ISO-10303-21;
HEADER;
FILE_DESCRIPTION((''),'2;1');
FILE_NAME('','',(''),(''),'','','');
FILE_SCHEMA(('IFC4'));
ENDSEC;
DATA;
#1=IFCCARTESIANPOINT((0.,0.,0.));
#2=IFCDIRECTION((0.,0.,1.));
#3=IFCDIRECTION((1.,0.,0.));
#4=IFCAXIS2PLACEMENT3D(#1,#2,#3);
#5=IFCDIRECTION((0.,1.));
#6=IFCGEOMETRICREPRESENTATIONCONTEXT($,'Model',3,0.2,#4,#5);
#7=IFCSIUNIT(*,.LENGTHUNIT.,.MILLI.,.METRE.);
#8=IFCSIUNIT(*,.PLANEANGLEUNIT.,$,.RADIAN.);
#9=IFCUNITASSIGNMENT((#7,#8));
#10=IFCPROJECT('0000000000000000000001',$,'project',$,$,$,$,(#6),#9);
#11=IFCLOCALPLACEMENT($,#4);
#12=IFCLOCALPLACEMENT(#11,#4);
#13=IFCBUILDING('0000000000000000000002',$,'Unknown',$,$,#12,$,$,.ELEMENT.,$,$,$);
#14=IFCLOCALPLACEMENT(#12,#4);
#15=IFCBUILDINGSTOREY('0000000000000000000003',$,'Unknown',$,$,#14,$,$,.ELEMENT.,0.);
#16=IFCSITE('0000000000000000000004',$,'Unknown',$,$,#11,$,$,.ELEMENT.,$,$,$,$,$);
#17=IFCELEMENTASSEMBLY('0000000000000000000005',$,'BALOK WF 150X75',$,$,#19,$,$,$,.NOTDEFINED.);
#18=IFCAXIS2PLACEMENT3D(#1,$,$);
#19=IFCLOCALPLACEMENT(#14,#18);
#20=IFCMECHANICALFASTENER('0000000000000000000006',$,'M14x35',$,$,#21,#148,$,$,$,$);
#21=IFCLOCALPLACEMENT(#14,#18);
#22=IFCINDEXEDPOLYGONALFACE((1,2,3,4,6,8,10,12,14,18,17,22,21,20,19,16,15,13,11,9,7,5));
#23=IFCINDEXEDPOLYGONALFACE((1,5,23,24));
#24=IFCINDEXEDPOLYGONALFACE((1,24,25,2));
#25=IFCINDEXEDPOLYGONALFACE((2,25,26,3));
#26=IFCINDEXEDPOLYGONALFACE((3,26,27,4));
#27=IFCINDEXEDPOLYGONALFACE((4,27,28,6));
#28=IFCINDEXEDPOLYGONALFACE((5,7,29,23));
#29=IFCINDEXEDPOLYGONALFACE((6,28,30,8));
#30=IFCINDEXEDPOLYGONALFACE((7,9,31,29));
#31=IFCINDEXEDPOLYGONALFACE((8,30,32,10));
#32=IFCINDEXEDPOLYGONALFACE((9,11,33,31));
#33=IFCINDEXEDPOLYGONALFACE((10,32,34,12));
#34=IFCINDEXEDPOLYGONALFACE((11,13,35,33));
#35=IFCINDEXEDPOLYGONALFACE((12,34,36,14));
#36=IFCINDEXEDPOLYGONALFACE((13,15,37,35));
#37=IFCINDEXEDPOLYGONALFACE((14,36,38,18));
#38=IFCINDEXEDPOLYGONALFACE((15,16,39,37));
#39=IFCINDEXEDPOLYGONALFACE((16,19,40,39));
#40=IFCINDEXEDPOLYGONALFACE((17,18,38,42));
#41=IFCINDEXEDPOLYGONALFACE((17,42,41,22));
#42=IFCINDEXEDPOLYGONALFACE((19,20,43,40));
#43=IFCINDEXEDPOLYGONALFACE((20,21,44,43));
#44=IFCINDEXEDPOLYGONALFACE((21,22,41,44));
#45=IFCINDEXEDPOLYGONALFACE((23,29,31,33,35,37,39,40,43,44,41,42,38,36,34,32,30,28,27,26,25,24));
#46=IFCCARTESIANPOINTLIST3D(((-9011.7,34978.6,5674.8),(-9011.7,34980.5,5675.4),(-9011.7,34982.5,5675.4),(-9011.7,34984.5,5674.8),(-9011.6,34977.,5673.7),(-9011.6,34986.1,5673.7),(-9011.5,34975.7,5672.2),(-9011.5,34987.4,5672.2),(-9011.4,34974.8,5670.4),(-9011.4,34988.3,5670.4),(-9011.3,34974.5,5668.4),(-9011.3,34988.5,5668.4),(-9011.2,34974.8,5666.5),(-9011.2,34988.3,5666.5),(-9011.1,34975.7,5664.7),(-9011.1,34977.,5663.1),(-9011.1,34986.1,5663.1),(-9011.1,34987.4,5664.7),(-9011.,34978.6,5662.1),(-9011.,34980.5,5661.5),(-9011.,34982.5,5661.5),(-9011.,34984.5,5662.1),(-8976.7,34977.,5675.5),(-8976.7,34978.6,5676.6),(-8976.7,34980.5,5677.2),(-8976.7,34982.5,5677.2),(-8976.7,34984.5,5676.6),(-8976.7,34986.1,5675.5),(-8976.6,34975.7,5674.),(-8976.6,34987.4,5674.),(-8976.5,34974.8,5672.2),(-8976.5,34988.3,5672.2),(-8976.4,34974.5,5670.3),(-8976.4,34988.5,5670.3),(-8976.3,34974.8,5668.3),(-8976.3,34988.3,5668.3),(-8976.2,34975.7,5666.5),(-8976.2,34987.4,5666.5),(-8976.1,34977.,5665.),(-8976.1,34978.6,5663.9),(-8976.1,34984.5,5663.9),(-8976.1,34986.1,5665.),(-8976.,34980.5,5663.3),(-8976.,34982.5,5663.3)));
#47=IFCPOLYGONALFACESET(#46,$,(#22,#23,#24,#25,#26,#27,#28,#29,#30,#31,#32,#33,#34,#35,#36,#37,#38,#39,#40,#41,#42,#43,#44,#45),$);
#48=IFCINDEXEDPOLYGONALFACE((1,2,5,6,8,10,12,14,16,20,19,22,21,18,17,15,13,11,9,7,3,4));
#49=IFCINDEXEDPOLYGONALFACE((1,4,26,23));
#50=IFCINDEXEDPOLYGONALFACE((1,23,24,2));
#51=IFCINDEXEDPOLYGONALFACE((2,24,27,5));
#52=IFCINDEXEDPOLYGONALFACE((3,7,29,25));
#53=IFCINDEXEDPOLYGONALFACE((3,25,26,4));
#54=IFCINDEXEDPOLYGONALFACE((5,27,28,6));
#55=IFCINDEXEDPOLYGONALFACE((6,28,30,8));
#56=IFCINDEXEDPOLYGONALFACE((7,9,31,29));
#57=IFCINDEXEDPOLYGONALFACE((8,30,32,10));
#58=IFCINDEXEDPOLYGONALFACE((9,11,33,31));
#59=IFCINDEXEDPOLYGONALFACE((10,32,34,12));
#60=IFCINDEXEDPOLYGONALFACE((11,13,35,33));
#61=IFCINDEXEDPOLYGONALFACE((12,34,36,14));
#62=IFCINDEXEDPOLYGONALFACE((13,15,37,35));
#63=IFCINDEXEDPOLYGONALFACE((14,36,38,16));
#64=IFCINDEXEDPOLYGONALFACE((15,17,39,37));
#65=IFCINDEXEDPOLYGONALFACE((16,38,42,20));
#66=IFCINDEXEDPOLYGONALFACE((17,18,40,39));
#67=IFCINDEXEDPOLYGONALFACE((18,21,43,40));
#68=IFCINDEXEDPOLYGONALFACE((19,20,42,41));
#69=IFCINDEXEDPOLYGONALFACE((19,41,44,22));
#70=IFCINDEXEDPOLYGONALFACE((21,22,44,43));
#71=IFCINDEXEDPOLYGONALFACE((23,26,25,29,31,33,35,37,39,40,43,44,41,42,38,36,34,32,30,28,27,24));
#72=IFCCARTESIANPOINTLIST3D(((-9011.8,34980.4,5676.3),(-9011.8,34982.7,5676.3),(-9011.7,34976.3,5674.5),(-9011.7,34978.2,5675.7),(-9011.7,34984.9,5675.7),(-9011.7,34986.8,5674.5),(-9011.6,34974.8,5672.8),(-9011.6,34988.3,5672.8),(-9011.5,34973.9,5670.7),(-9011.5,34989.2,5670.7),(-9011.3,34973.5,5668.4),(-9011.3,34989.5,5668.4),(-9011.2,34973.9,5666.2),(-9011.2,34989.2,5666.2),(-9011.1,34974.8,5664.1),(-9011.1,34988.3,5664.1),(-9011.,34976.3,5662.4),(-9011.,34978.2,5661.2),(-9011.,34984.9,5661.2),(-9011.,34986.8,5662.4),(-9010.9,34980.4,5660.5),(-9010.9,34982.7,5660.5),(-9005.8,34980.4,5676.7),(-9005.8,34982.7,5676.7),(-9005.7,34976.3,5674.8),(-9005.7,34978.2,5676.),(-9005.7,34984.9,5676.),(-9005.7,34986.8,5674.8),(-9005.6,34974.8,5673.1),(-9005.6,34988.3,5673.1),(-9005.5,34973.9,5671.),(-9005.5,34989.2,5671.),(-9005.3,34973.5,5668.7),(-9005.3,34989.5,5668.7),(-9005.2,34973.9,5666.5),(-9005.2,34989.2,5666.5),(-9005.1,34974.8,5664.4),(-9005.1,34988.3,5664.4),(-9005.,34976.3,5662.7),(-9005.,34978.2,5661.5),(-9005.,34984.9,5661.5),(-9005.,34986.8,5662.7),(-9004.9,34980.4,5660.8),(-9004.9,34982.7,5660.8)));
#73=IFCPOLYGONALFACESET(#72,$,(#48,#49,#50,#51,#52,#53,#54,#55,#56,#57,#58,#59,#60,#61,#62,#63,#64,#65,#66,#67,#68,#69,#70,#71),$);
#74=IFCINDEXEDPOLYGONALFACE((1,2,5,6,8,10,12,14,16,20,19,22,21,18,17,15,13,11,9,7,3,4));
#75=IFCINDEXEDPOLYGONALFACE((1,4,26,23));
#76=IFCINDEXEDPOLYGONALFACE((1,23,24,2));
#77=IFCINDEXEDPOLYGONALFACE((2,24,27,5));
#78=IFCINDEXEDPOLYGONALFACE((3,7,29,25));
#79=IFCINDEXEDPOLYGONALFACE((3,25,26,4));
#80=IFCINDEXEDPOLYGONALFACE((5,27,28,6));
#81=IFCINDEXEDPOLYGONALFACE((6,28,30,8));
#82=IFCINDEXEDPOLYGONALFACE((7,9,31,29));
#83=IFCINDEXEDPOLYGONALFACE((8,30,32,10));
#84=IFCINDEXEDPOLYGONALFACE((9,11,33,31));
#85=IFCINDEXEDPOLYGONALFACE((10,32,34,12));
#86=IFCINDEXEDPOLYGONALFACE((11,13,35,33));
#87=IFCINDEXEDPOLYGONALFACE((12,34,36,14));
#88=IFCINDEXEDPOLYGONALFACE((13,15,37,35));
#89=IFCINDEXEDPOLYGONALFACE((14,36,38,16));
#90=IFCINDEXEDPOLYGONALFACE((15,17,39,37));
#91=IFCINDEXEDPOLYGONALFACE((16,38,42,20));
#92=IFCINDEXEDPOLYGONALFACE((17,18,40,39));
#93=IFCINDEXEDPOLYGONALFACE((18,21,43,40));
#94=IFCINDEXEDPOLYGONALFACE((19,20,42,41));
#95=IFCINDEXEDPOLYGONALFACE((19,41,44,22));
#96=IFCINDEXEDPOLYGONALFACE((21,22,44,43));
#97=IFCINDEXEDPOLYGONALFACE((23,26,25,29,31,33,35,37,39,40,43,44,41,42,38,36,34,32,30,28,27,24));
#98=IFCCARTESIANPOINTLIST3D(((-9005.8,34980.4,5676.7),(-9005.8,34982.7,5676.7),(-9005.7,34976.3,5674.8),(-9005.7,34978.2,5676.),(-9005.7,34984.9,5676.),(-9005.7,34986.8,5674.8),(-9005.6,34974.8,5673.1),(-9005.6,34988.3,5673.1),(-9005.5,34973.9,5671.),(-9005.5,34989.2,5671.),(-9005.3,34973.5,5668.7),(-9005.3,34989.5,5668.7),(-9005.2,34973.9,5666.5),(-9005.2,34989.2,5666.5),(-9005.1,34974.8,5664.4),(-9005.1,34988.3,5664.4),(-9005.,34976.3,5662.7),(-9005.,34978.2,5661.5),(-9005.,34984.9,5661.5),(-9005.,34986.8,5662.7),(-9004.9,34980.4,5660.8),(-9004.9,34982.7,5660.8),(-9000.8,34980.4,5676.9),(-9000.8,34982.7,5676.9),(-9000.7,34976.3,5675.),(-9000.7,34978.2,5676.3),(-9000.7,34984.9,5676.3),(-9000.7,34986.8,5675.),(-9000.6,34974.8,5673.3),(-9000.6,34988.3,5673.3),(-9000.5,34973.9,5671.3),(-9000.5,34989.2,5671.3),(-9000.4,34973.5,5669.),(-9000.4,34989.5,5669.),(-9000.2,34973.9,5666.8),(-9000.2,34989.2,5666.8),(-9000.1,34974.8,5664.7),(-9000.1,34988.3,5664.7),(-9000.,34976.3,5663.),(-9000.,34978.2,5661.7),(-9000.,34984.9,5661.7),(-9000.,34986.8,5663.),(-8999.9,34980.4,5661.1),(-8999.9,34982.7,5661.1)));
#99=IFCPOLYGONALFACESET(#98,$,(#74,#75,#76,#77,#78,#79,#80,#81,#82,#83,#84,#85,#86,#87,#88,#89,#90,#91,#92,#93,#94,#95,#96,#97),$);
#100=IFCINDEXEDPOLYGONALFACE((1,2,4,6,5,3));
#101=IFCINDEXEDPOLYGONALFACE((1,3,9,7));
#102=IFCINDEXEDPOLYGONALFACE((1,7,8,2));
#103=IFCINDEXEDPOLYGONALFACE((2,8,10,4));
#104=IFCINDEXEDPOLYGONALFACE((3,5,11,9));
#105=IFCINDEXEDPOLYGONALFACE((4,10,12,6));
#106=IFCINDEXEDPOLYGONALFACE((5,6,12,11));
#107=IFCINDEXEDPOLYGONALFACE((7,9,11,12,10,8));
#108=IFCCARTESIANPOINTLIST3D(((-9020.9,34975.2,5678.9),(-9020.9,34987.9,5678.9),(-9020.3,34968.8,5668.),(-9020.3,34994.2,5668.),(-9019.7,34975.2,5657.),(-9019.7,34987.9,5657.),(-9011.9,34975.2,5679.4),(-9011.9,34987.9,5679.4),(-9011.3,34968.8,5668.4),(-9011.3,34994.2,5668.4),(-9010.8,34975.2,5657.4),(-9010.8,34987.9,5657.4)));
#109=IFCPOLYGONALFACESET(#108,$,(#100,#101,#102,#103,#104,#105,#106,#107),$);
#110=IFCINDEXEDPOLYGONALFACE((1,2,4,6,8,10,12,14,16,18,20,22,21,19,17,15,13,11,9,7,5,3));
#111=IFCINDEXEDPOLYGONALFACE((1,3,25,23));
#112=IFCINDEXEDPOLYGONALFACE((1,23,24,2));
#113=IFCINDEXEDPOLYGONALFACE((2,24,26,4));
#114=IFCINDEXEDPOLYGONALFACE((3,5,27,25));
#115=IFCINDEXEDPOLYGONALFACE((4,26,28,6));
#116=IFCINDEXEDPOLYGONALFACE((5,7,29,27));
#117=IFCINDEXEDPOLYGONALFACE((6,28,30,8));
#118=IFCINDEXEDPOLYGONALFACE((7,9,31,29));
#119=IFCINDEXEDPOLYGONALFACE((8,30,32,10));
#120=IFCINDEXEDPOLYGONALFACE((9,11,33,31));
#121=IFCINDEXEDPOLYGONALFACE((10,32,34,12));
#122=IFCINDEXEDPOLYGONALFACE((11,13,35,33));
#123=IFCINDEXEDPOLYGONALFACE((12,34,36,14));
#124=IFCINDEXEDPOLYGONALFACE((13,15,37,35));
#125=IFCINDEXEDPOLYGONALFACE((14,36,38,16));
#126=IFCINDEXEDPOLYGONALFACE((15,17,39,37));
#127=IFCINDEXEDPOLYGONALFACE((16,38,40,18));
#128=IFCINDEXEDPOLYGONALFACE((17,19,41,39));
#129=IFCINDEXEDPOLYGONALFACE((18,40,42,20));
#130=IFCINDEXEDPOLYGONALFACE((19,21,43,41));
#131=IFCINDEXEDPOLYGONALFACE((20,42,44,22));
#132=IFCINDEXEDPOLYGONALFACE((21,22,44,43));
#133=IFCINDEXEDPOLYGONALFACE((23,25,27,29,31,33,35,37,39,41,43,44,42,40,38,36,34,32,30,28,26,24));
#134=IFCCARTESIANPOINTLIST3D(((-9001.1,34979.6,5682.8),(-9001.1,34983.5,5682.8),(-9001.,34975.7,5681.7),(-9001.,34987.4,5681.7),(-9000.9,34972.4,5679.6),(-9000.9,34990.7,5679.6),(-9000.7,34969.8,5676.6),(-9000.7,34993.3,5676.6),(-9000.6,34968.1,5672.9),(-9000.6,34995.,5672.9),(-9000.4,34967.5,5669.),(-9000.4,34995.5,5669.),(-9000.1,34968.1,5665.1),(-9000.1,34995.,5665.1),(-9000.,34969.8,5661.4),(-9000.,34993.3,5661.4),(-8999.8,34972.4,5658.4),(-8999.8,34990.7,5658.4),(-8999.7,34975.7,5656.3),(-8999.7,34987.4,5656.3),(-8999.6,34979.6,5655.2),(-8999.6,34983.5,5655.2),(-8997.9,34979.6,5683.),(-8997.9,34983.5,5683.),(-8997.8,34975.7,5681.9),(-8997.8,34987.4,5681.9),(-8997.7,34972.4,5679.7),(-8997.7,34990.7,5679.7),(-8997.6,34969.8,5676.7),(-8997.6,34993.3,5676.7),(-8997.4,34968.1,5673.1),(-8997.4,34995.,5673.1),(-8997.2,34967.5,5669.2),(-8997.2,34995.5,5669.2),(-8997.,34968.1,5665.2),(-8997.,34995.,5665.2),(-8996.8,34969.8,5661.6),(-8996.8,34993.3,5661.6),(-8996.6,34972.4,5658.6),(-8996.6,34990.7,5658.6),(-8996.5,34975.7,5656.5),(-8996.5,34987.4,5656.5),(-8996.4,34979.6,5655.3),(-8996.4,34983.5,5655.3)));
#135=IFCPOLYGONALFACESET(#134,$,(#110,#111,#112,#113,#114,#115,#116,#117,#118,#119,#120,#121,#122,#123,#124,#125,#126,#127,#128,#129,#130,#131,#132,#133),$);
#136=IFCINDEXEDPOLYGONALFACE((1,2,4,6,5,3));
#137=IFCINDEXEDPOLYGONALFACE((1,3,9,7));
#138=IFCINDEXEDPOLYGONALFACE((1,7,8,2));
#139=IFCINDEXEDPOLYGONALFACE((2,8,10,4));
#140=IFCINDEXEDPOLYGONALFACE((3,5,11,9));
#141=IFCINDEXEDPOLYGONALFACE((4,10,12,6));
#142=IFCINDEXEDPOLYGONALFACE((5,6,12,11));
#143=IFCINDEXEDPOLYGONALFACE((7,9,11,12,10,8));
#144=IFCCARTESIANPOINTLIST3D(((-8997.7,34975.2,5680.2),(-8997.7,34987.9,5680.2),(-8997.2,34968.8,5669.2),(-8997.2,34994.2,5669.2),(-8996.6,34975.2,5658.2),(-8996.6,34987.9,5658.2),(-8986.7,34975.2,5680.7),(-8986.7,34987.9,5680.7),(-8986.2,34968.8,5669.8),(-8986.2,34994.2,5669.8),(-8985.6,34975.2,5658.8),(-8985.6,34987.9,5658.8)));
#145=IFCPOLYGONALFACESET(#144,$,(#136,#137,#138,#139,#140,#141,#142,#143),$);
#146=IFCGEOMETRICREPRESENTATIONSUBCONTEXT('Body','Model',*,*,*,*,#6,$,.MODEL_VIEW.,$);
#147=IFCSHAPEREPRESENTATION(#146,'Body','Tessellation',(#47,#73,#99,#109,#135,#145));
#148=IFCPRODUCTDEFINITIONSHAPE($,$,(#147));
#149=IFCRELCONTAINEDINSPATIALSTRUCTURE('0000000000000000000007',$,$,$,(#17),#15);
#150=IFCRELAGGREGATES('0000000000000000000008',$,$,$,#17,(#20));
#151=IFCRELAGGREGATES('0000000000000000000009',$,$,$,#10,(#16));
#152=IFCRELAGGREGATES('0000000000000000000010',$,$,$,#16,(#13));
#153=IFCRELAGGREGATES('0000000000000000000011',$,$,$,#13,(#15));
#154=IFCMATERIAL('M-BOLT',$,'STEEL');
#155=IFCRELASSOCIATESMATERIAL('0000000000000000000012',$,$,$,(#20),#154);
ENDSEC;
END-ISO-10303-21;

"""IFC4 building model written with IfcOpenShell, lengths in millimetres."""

from ifc_helpers import new_model, si_unit, direction, frame, origin_with_axes, place, context, subcontext, project, spatial, line, arc, indexed_curve, outline, extrude, source, transform, mapped, material, element, aggregate, save


model = new_model("IFC4")

# Units and contexts
model_context = context("Model", 3, precision=0.2, world=origin_with_axes(), true_north=direction((0.0, 1.0)))
body_context = subcontext(model_context, "Body", "Model", "MODEL_VIEW")
ifc_project = project(units=[si_unit("LENGTHUNIT", "METRE", prefix="MILLI"), si_unit("PLANEANGLEUNIT", "RADIAN")], contexts=[model_context])

# Site, building, storey
site_placement = place(None, origin_with_axes())
site = spatial("IfcSite", under=ifc_project, at=site_placement, Name="Unknown", CompositionType="ELEMENT")
building_placement = place(site_placement, origin_with_axes())
building = spatial("IfcBuilding", under=site, at=building_placement, Name="Unknown", CompositionType="ELEMENT")
storey_placement = place(building_placement, origin_with_axes())
storey = spatial("IfcBuildingStorey", under=building, at=storey_placement, Name="Unknown", CompositionType="ELEMENT", Elevation=0.0)

# Shared definitions
ifc_material_1 = material(Name="M-BOLT", Category="STEEL")

# Element assembly, mechanical fastener
assembly_1_placement = place(storey_placement, frame((-9001.5, 35225.4, 5643.9), z_axis=(-0.99863, 0.0, -0.052336), x_axis=(0.0, -1.0, 0.000001)))
assembly_1 = element("IfcElementAssembly", 1, at=assembly_1_placement, inside=storey, Name="BALOK WF 150X75", PredefinedType="NOTDEFINED")
shared_shape_1 = source(origin_with_axes(), body_context, "Body", "SweptSolid", [
    extrude(outline(indexed_curve([(7.0, 0.0), (0.0, 7.0), (-7.0, 0.0), (0.0, -7.0)], segments=[arc(1, 2, 3), arc(3, 4, 1)])), frame((0.0, 0.0, 0.0), z_axis=(0.0, 0.0, -1.0), x_axis=(0.0, 1.0, 0.0)), (0.0, 0.0, 1.0), 35.0),
    extrude(outline(indexed_curve([(8.0, 0.0), (0.0, 8.0), (-8.0, 0.0), (0.0, -8.0)], segments=[arc(1, 2, 3), arc(3, 4, 1)])), frame((0.0, 0.0, 0.0), z_axis=(0.0, 0.0, -1.0), x_axis=(0.0, 1.0, 0.0)), (0.0, 0.0, 1.0), 6.0),
    extrude(outline(indexed_curve([(8.0, 0.0), (0.0, 8.0), (-8.0, 0.0), (0.0, -8.0)], segments=[arc(1, 2, 3), arc(3, 4, 1)])), frame((0.0, 0.0, -6.0), z_axis=(0.0, 0.0, -1.0), x_axis=(0.0, 1.0, 0.0)), (0.0, 0.0, 1.0), 5.0),
    extrude(outline(indexed_curve([(12.7, 0.0), (6.4, 11.0), (-6.4, 11.0), (-12.7, 0.0), (-6.4, -11.0), (6.4, -11.0)], segments=[line(1, 2, 3, 4, 5, 6, 1)])), frame((0.0, 0.0, 9.0), z_axis=(0.0, 0.0, -1.0), x_axis=(0.0, 1.0, 0.0)), (0.0, 0.0, 1.0), 9.0),
    extrude(outline(indexed_curve([(14.0, 0.0), (0.0, 14.0), (-14.0, 0.0), (0.0, -14.0)], segments=[arc(1, 2, 3), arc(3, 4, 1)])), frame((0.0, 0.0, -11.0), z_axis=(0.0, 0.0, -1.0), x_axis=(0.0, 1.0, 0.0)), (0.0, 0.0, 1.0), 3.2),
    extrude(outline(indexed_curve([(12.7, 0.0), (6.4, 11.0), (-6.4, 11.0), (-12.7, 0.0), (-6.4, -11.0), (6.4, -11.0)], segments=[line(1, 2, 3, 4, 5, 6, 1)])), frame((0.0, 0.0, -14.2), z_axis=(0.0, 0.0, -1.0), x_axis=(0.0, 1.0, 0.0)), (0.0, 0.0, 1.0), 11.0),
])
mechanical_fastener_1_placement = place(assembly_1_placement, frame((243.9, 25.0, 8.5), z_axis=(0.000006, 0.0, 1.0), x_axis=(-0.000001, -1.0, 0.0)))
mechanical_fastener_1 = element("IfcMechanicalFastener", 2, at=mechanical_fastener_1_placement, material=ifc_material_1, Name="M14x35", context=body_context, shape_type="MappedRepresentation", body=[
    mapped(shared_shape_1, transform((0.0, 0.0, 0.0))),
])

aggregate(assembly_1, [mechanical_fastener_1])

save(model, "model.ifc")
